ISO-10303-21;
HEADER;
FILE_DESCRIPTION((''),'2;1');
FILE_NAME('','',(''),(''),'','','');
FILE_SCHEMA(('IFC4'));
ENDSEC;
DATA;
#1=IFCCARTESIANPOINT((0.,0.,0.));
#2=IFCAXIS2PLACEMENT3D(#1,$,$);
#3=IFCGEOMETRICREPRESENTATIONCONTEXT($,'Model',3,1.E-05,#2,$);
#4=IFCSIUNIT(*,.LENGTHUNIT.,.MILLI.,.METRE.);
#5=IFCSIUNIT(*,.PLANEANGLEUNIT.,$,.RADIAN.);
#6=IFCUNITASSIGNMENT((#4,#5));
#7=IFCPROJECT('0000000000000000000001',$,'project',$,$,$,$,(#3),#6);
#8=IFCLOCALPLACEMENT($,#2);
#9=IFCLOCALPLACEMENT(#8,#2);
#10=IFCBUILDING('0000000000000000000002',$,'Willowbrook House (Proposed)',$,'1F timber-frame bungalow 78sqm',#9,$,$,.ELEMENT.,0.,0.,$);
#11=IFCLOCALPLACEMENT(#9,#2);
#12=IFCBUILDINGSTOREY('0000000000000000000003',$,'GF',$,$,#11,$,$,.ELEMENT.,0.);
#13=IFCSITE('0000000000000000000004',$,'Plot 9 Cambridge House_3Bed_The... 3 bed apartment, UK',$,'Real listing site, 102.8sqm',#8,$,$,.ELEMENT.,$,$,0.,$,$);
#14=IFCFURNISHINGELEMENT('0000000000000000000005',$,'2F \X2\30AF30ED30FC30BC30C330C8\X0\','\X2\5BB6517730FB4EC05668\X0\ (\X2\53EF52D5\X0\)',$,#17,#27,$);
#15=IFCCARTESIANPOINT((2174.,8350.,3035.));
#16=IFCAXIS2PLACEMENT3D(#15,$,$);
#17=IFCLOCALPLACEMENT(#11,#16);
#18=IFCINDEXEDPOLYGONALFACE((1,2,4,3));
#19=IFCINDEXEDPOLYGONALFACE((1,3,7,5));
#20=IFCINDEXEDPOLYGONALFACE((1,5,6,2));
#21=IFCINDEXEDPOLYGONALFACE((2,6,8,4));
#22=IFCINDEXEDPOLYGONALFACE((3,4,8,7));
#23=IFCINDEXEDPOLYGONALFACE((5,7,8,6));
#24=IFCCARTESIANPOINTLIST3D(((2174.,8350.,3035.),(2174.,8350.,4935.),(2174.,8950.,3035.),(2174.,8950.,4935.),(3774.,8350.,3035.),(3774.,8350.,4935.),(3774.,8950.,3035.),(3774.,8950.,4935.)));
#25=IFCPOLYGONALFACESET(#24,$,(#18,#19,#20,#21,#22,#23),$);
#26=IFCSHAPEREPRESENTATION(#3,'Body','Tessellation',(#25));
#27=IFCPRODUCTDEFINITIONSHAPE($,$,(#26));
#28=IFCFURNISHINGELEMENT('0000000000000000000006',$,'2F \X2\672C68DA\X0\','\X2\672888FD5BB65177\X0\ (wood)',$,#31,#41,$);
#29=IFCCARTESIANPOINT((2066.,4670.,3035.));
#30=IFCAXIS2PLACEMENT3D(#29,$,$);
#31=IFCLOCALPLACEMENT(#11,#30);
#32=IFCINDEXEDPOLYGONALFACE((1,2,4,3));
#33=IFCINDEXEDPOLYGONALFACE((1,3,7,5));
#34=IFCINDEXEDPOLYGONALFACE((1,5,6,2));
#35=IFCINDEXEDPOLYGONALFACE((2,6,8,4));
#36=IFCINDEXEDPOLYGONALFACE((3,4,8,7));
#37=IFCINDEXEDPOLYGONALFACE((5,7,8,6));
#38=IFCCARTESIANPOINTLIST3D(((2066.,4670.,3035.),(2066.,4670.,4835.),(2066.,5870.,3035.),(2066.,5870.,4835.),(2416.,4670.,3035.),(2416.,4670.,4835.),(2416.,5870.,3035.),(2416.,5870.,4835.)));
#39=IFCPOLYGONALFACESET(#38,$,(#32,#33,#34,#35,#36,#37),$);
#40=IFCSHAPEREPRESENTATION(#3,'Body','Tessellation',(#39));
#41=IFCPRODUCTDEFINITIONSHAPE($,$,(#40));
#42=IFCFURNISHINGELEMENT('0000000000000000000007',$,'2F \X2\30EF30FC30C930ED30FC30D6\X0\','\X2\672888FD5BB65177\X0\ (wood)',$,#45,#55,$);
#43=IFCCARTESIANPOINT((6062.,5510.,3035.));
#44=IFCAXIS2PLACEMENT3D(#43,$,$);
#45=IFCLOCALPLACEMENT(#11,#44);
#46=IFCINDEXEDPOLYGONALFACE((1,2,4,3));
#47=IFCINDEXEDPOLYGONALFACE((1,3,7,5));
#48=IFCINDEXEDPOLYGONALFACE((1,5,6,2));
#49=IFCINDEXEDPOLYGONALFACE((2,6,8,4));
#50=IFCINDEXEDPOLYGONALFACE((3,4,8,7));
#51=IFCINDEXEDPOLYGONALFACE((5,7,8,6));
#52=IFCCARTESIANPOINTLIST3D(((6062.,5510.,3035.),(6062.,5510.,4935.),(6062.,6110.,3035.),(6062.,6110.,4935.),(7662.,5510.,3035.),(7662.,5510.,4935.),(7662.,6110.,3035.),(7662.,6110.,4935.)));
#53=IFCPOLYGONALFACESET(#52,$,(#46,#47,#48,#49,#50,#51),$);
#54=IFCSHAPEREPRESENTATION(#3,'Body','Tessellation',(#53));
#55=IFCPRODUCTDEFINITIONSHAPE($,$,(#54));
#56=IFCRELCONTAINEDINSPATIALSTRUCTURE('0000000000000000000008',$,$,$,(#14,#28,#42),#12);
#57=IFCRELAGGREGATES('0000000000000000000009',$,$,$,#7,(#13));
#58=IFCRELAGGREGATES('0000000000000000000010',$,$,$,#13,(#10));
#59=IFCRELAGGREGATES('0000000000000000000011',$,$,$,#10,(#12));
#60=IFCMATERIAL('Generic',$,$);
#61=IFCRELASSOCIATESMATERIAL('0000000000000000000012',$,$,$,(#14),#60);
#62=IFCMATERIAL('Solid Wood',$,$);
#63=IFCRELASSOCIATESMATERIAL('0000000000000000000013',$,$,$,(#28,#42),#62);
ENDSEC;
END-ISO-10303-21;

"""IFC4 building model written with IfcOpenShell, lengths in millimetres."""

from ifc_helpers import new_model, si_unit, frame, frame_2d, origin, place, context, project, spatial, rectangle, extrude, material, element, save


model = new_model("IFC4")

# Units and contexts
model_context = context("Model", 3, precision=1e-05, world=origin())
ifc_project = project(units=[si_unit("LENGTHUNIT", "METRE", prefix="MILLI"), si_unit("PLANEANGLEUNIT", "RADIAN")], contexts=[model_context])

# Site, building, storey
site_placement = place(None, origin())
site = spatial("IfcSite", under=ifc_project, at=site_placement, Name="Plot 9 Cambridge House_3Bed_The... 3 bed apartment, UK", ObjectType="Real listing site, 102.8sqm", CompositionType="ELEMENT", RefElevation=0.0)
building_placement = place(site_placement, origin())
building = spatial("IfcBuilding", under=site, at=building_placement, Name="Willowbrook House (Proposed)", ObjectType="1F timber-frame bungalow 78sqm", CompositionType="ELEMENT", ElevationOfRefHeight=0.0, ElevationOfTerrain=0.0)
storey_placement = place(building_placement, origin())
storey = spatial("IfcBuildingStorey", under=building, at=storey_placement, Name="GF", CompositionType="ELEMENT", Elevation=0.0)

# Shared definitions
ifc_material_1 = material(Name="Solid Wood")

# Shared definitions
ifc_material_2 = material(Name="Generic")

# Furnishing elements
furnishing_1_placement = place(storey_placement, frame((2174.0, 8350.0, 3035.0)))
element("IfcFurnishingElement", 1, at=furnishing_1_placement, inside=storey, material=ifc_material_2, Name="2F クローゼット", Description="家具・什器 (可動)", context=model_context, shape_type="SweptSolid", body=[
    extrude(rectangle(XDim=1600.0, YDim=600.0, at=frame_2d((800.0, 300.0))), frame((2174.0, 8350.0, 3035.0)), (0.0, 0.0, 1.0), 1900.0),
])
furnishing_2_placement = place(storey_placement, frame((2066.0, 4670.0, 3035.0)))
element("IfcFurnishingElement", 2, at=furnishing_2_placement, inside=storey, material=ifc_material_1, Name="2F 本棚", Description="木製家具 (wood)", context=model_context, shape_type="SweptSolid", body=[
    extrude(rectangle(XDim=350.0, YDim=1200.0, at=frame_2d((175.0, 600.0))), frame((2066.0, 4670.0, 3035.0)), (0.0, 0.0, 1.0), 1800.0),
])
furnishing_3_placement = place(storey_placement, frame((6062.0, 5510.0, 3035.0)))
element("IfcFurnishingElement", 3, at=furnishing_3_placement, inside=storey, material=ifc_material_1, Name="2F ワードローブ", Description="木製家具 (wood)", context=model_context, shape_type="SweptSolid", body=[
    extrude(rectangle(XDim=1600.0, YDim=600.0, at=frame_2d((800.0, 300.0))), frame((6062.0, 5510.0, 3035.0)), (0.0, 0.0, 1.0), 1900.0),
])

save(model, "model.ifc")
